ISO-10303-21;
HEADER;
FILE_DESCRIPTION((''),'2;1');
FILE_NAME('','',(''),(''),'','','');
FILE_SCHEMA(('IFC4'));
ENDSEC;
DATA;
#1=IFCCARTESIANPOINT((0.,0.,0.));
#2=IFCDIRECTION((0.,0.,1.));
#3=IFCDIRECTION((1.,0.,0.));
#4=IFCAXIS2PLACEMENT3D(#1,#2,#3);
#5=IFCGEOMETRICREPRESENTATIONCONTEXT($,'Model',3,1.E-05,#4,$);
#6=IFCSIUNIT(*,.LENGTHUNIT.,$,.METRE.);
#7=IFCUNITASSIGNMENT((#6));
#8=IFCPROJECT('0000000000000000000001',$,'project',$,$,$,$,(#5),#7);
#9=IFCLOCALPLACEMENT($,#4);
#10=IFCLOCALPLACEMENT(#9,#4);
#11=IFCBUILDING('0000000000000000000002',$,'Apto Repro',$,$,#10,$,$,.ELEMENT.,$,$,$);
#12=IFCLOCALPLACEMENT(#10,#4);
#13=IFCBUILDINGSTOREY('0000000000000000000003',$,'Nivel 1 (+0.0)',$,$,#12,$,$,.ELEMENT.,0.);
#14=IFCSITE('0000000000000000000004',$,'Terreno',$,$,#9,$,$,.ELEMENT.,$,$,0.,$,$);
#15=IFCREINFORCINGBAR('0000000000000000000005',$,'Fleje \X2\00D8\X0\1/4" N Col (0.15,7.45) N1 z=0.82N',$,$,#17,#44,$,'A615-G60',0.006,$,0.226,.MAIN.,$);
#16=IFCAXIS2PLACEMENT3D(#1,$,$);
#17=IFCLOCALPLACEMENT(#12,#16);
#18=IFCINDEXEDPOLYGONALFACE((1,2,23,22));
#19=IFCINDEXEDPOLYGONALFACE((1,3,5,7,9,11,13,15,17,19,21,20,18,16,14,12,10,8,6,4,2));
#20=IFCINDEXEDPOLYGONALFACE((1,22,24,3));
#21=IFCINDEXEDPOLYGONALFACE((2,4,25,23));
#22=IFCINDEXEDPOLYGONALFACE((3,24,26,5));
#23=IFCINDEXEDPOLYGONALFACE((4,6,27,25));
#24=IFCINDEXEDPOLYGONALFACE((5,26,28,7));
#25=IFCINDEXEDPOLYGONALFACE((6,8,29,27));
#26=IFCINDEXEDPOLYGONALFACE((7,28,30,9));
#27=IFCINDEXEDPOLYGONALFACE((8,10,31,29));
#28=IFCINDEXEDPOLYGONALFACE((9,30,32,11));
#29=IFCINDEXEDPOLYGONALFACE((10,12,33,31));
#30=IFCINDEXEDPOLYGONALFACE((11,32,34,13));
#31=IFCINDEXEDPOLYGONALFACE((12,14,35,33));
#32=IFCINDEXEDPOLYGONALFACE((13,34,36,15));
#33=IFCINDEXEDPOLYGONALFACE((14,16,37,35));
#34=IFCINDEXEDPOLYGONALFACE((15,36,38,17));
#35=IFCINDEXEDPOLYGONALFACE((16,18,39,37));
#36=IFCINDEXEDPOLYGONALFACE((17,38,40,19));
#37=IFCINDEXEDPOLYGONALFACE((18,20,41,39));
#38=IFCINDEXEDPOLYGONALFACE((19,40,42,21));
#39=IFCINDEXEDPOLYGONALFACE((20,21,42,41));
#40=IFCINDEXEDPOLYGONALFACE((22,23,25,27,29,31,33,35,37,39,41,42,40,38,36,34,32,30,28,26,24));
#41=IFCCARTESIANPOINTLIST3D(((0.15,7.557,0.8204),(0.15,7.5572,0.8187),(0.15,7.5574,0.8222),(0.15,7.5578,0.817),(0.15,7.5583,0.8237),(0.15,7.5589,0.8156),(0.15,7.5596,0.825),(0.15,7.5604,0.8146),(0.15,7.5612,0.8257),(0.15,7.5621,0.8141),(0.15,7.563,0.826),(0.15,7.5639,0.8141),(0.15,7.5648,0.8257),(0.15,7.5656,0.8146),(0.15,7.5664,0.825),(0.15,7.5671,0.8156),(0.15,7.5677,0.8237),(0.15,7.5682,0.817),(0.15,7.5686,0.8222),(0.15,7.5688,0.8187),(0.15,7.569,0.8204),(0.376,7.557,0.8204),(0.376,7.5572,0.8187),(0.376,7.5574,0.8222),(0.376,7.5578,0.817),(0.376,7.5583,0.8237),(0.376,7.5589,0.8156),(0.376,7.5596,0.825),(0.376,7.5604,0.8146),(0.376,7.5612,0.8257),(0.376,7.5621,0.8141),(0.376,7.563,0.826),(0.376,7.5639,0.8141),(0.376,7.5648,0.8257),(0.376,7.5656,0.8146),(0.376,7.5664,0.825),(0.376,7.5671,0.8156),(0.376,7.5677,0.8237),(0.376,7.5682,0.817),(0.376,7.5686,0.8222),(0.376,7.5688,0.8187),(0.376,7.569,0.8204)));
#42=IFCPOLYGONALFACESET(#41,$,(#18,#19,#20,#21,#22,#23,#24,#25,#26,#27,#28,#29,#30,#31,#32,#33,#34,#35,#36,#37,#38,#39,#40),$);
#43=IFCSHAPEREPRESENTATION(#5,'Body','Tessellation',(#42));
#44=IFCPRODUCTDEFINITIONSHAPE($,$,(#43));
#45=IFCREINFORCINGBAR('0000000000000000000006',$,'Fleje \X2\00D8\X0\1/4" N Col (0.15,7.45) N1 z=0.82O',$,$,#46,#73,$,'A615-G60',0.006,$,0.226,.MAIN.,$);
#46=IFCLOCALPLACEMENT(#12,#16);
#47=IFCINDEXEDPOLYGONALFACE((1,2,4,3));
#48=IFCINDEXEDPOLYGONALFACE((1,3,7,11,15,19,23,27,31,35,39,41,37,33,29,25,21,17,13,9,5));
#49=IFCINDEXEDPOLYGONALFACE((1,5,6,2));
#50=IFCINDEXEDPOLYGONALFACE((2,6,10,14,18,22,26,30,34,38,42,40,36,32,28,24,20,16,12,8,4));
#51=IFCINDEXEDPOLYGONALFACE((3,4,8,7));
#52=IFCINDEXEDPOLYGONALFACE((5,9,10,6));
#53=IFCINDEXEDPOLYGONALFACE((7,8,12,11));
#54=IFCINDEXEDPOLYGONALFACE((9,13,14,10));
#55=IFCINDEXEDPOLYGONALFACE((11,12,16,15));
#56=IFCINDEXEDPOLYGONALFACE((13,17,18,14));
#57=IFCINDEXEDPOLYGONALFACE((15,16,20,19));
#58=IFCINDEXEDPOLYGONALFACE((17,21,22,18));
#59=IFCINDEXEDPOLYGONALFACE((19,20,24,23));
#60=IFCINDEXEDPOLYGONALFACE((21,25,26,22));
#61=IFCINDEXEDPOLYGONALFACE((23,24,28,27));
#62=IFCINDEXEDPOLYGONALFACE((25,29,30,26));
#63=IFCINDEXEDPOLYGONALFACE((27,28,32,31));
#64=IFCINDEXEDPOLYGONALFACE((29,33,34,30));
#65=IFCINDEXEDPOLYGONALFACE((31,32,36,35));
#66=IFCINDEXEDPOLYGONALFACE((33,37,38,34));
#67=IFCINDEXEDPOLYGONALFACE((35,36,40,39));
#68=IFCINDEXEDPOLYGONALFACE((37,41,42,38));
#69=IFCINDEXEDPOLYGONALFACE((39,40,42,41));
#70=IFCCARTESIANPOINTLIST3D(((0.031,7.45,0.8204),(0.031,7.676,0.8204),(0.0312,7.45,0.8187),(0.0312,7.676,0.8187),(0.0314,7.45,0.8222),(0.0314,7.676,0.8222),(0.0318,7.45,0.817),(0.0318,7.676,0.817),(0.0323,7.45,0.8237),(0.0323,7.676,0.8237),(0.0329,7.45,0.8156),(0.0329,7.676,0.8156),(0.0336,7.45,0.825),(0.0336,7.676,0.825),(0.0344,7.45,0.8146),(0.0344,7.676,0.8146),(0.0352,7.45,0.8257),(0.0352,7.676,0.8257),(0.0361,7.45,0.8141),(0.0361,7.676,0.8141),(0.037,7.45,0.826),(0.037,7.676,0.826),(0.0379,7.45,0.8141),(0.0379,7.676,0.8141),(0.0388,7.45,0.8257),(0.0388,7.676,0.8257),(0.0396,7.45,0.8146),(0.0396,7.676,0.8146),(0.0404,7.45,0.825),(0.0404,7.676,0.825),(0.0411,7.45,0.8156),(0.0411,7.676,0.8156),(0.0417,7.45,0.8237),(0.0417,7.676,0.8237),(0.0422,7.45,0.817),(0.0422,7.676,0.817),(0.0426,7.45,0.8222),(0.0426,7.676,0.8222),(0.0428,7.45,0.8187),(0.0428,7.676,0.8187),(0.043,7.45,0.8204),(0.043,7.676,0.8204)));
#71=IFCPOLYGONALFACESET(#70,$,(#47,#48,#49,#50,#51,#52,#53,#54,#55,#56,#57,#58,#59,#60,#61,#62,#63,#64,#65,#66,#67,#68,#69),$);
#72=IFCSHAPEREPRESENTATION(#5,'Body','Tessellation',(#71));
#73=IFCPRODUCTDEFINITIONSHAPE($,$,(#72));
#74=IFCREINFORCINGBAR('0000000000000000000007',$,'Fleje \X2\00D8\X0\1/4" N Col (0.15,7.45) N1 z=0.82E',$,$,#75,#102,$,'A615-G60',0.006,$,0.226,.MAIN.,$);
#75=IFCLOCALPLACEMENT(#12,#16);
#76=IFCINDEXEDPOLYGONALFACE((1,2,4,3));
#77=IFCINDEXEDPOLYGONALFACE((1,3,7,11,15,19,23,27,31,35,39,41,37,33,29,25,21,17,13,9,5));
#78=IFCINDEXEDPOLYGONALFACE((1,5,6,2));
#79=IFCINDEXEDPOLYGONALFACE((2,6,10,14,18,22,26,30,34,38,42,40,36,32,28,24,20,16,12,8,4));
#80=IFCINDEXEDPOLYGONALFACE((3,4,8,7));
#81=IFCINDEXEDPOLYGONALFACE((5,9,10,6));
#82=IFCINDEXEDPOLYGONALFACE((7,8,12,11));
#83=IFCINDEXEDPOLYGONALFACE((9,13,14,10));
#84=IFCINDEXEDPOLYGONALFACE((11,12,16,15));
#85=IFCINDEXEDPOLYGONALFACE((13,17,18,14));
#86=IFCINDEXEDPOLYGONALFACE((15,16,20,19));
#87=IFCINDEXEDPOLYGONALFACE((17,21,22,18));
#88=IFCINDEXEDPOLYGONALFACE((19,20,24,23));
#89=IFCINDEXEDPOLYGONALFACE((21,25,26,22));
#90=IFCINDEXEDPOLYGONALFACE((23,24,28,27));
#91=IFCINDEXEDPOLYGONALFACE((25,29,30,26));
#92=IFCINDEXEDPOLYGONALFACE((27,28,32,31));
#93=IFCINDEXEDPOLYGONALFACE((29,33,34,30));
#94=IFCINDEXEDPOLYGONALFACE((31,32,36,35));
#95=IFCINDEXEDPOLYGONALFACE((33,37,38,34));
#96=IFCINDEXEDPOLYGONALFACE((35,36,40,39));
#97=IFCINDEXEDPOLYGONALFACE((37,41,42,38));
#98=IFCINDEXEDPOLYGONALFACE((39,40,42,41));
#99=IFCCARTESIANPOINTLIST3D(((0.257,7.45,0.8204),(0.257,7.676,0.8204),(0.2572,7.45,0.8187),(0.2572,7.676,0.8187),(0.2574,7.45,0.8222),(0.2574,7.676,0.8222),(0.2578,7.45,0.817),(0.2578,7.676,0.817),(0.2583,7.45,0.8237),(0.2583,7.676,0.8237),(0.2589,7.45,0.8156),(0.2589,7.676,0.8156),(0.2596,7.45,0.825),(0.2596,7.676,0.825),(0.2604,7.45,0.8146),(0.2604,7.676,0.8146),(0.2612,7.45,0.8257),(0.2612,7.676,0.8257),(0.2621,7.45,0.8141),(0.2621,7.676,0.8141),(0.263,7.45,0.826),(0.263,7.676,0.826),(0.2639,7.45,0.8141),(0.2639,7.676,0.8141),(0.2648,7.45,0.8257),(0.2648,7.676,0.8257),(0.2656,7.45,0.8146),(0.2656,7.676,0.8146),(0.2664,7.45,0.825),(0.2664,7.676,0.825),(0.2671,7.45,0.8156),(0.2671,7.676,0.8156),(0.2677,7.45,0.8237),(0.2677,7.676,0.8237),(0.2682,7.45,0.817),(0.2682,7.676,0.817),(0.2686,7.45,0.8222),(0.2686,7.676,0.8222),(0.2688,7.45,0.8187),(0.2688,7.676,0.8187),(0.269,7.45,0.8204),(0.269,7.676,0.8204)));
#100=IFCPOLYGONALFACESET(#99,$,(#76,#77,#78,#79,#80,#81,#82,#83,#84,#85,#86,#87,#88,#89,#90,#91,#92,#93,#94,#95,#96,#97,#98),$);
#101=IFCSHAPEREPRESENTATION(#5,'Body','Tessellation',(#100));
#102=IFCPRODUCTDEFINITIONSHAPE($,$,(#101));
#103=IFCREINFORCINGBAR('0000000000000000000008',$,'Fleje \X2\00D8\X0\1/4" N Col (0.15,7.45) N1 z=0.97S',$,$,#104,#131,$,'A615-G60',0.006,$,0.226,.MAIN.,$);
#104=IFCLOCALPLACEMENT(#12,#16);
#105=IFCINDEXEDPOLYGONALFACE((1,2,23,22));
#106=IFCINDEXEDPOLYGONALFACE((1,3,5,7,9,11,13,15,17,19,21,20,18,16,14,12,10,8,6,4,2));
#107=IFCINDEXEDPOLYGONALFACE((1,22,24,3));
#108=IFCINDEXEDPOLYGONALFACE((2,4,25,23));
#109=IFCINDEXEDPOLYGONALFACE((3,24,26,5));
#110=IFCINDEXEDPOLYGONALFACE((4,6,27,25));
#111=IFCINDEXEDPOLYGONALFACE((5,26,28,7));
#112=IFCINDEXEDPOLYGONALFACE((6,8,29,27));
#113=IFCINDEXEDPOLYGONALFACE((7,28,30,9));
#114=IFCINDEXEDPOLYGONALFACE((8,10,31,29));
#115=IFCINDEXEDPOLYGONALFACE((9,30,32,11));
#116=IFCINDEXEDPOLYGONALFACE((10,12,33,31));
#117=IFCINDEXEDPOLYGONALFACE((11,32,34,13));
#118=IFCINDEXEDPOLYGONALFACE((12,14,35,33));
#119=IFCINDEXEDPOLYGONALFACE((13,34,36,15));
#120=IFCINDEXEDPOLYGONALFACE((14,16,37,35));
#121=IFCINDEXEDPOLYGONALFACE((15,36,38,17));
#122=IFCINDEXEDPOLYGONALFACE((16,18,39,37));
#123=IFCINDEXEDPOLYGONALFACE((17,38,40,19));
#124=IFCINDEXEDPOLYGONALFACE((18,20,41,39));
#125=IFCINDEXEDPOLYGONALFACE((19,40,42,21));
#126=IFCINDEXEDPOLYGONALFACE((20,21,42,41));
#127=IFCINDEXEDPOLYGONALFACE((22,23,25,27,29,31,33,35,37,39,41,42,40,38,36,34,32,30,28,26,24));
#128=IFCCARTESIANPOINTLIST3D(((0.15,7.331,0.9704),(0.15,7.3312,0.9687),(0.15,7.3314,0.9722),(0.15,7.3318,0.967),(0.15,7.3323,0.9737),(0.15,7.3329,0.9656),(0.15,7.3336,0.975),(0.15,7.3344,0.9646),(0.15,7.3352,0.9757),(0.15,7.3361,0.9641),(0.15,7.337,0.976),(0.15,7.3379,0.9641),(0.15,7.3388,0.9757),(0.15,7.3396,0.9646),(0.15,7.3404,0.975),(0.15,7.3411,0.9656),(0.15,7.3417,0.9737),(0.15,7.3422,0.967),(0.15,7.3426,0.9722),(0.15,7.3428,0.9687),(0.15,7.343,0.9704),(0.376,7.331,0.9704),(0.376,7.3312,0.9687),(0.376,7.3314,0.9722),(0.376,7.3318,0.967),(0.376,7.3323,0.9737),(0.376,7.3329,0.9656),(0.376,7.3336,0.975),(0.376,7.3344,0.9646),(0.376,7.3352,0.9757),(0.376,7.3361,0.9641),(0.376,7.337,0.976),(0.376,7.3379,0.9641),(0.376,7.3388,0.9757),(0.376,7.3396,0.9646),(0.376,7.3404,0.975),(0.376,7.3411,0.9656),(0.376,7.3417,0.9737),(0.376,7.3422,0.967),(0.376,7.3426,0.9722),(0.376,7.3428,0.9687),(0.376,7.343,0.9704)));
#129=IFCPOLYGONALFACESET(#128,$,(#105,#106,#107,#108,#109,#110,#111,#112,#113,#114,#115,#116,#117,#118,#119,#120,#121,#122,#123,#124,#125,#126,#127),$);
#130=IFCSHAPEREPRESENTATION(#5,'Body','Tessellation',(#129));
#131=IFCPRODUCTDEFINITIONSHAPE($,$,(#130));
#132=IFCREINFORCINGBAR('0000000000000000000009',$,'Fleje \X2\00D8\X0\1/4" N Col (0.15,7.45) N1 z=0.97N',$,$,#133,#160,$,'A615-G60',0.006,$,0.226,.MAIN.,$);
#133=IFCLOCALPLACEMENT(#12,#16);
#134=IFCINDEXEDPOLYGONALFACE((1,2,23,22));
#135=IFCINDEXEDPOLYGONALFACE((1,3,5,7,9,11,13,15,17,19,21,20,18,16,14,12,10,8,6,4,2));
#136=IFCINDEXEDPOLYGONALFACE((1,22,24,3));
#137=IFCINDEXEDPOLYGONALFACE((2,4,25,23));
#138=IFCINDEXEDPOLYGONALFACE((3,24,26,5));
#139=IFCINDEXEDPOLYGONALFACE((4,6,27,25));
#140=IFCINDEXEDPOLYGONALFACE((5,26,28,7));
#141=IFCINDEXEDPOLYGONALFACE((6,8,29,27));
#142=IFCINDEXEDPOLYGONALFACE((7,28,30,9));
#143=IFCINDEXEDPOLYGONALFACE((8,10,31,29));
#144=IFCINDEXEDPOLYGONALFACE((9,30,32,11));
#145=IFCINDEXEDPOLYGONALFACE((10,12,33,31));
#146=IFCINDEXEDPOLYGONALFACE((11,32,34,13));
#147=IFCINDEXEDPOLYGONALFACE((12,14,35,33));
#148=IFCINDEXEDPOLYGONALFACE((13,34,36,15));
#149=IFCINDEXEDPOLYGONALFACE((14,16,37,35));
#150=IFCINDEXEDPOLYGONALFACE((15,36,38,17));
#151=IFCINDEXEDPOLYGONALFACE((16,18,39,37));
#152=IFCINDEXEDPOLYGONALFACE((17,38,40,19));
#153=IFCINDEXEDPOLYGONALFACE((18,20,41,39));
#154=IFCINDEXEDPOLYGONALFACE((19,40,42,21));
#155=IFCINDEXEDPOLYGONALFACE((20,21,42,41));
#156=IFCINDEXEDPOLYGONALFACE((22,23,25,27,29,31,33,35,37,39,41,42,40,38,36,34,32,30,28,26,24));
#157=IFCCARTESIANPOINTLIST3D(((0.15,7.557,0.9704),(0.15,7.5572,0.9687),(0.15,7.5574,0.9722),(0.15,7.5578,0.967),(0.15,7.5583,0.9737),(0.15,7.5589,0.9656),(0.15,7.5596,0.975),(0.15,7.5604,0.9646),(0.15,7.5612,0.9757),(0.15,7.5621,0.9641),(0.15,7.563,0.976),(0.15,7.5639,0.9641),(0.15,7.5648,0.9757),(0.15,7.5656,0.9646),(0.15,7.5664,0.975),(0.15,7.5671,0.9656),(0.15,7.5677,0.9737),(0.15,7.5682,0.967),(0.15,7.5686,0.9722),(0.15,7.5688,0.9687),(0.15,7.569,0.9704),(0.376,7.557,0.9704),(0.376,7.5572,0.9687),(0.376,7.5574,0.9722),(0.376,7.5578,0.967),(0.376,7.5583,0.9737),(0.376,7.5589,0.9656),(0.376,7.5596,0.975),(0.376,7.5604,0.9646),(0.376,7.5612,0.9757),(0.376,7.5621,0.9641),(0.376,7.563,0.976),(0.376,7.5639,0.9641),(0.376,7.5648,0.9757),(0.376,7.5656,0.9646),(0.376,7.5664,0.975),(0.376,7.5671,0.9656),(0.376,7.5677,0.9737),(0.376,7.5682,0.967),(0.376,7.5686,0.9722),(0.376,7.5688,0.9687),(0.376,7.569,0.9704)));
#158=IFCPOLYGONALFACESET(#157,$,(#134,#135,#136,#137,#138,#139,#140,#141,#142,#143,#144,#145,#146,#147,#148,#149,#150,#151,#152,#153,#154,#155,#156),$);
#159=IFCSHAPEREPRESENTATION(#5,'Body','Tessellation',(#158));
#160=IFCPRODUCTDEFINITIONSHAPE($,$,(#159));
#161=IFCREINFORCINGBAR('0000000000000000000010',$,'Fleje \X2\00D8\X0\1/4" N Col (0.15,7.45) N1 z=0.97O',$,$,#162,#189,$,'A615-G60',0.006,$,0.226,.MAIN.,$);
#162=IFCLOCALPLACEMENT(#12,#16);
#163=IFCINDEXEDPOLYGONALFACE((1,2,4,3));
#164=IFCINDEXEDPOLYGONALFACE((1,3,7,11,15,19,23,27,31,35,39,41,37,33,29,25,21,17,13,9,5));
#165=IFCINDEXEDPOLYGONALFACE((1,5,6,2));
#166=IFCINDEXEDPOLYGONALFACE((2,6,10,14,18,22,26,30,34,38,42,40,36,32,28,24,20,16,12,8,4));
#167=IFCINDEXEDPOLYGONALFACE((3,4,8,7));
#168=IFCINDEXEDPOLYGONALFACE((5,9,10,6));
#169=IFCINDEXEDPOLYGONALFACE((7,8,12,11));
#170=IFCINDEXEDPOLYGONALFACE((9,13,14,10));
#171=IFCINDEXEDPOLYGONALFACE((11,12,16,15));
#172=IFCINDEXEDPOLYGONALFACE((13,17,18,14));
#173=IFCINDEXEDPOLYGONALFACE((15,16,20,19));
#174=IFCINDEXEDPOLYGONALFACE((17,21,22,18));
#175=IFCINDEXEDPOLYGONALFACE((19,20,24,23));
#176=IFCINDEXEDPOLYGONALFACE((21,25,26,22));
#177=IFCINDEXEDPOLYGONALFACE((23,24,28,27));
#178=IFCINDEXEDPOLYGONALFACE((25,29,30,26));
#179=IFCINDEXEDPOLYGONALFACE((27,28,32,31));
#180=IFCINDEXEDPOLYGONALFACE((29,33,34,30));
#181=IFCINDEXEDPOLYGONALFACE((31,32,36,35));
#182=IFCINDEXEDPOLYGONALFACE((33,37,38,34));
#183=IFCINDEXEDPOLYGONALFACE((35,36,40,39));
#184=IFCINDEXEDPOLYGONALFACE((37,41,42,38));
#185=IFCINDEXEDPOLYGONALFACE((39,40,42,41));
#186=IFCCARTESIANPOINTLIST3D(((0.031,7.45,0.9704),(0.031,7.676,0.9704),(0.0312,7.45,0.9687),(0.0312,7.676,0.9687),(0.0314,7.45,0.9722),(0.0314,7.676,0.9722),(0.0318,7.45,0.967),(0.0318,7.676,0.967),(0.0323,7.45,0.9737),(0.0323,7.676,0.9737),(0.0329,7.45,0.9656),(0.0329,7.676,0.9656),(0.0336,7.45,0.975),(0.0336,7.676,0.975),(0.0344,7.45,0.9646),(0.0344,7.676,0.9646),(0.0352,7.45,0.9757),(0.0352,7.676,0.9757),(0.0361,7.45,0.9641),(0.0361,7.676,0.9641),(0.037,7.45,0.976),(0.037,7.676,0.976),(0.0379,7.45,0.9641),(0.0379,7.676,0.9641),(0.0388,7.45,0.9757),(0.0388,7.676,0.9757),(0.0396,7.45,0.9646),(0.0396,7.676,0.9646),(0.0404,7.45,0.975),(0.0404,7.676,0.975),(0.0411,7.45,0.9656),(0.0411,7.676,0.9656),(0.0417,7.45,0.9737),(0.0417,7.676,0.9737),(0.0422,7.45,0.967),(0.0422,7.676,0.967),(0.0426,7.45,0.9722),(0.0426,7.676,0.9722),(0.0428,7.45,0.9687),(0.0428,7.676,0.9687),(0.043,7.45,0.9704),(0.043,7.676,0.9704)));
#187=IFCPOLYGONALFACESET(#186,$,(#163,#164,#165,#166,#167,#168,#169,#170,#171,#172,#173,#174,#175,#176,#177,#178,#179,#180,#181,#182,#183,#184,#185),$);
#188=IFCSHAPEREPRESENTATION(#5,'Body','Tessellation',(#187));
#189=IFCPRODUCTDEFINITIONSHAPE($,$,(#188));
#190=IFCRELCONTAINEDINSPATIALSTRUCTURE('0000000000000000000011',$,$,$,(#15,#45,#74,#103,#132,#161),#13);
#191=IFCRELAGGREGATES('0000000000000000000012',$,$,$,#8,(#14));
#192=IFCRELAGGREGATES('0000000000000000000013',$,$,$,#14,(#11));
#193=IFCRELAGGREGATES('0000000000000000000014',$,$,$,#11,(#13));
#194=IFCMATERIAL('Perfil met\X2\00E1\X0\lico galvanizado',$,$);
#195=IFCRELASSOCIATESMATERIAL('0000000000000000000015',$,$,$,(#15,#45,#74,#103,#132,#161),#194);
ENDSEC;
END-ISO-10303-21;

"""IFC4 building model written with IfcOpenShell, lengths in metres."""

from ifc_helpers import new_model, si_unit, frame, origin_with_axes, origin_2d_with_axis, place, context, project, spatial, circle, extrude, material, element, save


model = new_model("IFC4")

# Units and contexts
model_context = context("Model", 3, precision=1e-05, world=origin_with_axes())
ifc_project = project(units=[si_unit("LENGTHUNIT", "METRE")], contexts=[model_context])

# Site, building, storey
site_placement = place(None, origin_with_axes())
site = spatial("IfcSite", under=ifc_project, at=site_placement, Name="Terreno", CompositionType="ELEMENT", RefElevation=0.0)
building_placement = place(site_placement, origin_with_axes())
building = spatial("IfcBuilding", under=site, at=building_placement, Name="Apto Repro", CompositionType="ELEMENT")
storey_placement = place(building_placement, origin_with_axes())
storey = spatial("IfcBuildingStorey", under=building, at=storey_placement, Name="Nivel 1 (+0.0)", CompositionType="ELEMENT", Elevation=0.0)

# Reinforcing bars
ifc_material = material(Name="Perfil metálico galvanizado")
reinforcing_bar_1_placement = place(storey_placement, origin_with_axes())
element("IfcReinforcingBar", 1, at=reinforcing_bar_1_placement, inside=storey, material=ifc_material, Name="Fleje Ø1/4\" N Col (0.15,7.45) N1 z=0.82N", SteelGrade="A615-G60", BarLength=0.226, NominalDiameter=0.006, PredefinedType="MAIN", context=model_context, shape_type="SweptSolid", body=[
    extrude(circle(Radius=0.006, at=origin_2d_with_axis()), frame((0.15, 7.563, 0.82), z_axis=(1.0, 0.0, 0.0), x_axis=(0.0, 0.0, 1.0)), (0.0, 0.0, 1.0), 0.226),
])
reinforcing_bar_2_placement = place(storey_placement, origin_with_axes())
element("IfcReinforcingBar", 2, at=reinforcing_bar_2_placement, inside=storey, material=ifc_material, Name="Fleje Ø1/4\" N Col (0.15,7.45) N1 z=0.82O", SteelGrade="A615-G60", BarLength=0.226, NominalDiameter=0.006, PredefinedType="MAIN", context=model_context, shape_type="SweptSolid", body=[
    extrude(circle(Radius=0.006, at=origin_2d_with_axis()), frame((0.037, 7.45, 0.82), z_axis=(0.0, 1.0, 0.0), x_axis=(0.0, 0.0, 1.0)), (0.0, 0.0, 1.0), 0.226),
])
reinforcing_bar_3_placement = place(storey_placement, origin_with_axes())
element("IfcReinforcingBar", 3, at=reinforcing_bar_3_placement, inside=storey, material=ifc_material, Name="Fleje Ø1/4\" N Col (0.15,7.45) N1 z=0.82E", SteelGrade="A615-G60", BarLength=0.226, NominalDiameter=0.006, PredefinedType="MAIN", context=model_context, shape_type="SweptSolid", body=[
    extrude(circle(Radius=0.006, at=origin_2d_with_axis()), frame((0.263, 7.45, 0.82), z_axis=(0.0, 1.0, 0.0), x_axis=(0.0, 0.0, 1.0)), (0.0, 0.0, 1.0), 0.226),
])
reinforcing_bar_4_placement = place(storey_placement, origin_with_axes())
element("IfcReinforcingBar", 4, at=reinforcing_bar_4_placement, inside=storey, material=ifc_material, Name="Fleje Ø1/4\" N Col (0.15,7.45) N1 z=0.97S", SteelGrade="A615-G60", BarLength=0.226, NominalDiameter=0.006, PredefinedType="MAIN", context=model_context, shape_type="SweptSolid", body=[
    extrude(circle(Radius=0.006, at=origin_2d_with_axis()), frame((0.15, 7.337, 0.97), z_axis=(1.0, 0.0, 0.0), x_axis=(0.0, 0.0, 1.0)), (0.0, 0.0, 1.0), 0.226),
])
reinforcing_bar_5_placement = place(storey_placement, origin_with_axes())
element("IfcReinforcingBar", 5, at=reinforcing_bar_5_placement, inside=storey, material=ifc_material, Name="Fleje Ø1/4\" N Col (0.15,7.45) N1 z=0.97N", SteelGrade="A615-G60", BarLength=0.226, NominalDiameter=0.006, PredefinedType="MAIN", context=model_context, shape_type="SweptSolid", body=[
    extrude(circle(Radius=0.006, at=origin_2d_with_axis()), frame((0.15, 7.563, 0.97), z_axis=(1.0, 0.0, 0.0), x_axis=(0.0, 0.0, 1.0)), (0.0, 0.0, 1.0), 0.226),
])
reinforcing_bar_6_placement = place(storey_placement, origin_with_axes())
element("IfcReinforcingBar", 6, at=reinforcing_bar_6_placement, inside=storey, material=ifc_material, Name="Fleje Ø1/4\" N Col (0.15,7.45) N1 z=0.97O", SteelGrade="A615-G60", BarLength=0.226, NominalDiameter=0.006, PredefinedType="MAIN", context=model_context, shape_type="SweptSolid", body=[
    extrude(circle(Radius=0.006, at=origin_2d_with_axis()), frame((0.037, 7.45, 0.97), z_axis=(0.0, 1.0, 0.0), x_axis=(0.0, 0.0, 1.0)), (0.0, 0.0, 1.0), 0.226),
])

save(model, "model.ifc")
